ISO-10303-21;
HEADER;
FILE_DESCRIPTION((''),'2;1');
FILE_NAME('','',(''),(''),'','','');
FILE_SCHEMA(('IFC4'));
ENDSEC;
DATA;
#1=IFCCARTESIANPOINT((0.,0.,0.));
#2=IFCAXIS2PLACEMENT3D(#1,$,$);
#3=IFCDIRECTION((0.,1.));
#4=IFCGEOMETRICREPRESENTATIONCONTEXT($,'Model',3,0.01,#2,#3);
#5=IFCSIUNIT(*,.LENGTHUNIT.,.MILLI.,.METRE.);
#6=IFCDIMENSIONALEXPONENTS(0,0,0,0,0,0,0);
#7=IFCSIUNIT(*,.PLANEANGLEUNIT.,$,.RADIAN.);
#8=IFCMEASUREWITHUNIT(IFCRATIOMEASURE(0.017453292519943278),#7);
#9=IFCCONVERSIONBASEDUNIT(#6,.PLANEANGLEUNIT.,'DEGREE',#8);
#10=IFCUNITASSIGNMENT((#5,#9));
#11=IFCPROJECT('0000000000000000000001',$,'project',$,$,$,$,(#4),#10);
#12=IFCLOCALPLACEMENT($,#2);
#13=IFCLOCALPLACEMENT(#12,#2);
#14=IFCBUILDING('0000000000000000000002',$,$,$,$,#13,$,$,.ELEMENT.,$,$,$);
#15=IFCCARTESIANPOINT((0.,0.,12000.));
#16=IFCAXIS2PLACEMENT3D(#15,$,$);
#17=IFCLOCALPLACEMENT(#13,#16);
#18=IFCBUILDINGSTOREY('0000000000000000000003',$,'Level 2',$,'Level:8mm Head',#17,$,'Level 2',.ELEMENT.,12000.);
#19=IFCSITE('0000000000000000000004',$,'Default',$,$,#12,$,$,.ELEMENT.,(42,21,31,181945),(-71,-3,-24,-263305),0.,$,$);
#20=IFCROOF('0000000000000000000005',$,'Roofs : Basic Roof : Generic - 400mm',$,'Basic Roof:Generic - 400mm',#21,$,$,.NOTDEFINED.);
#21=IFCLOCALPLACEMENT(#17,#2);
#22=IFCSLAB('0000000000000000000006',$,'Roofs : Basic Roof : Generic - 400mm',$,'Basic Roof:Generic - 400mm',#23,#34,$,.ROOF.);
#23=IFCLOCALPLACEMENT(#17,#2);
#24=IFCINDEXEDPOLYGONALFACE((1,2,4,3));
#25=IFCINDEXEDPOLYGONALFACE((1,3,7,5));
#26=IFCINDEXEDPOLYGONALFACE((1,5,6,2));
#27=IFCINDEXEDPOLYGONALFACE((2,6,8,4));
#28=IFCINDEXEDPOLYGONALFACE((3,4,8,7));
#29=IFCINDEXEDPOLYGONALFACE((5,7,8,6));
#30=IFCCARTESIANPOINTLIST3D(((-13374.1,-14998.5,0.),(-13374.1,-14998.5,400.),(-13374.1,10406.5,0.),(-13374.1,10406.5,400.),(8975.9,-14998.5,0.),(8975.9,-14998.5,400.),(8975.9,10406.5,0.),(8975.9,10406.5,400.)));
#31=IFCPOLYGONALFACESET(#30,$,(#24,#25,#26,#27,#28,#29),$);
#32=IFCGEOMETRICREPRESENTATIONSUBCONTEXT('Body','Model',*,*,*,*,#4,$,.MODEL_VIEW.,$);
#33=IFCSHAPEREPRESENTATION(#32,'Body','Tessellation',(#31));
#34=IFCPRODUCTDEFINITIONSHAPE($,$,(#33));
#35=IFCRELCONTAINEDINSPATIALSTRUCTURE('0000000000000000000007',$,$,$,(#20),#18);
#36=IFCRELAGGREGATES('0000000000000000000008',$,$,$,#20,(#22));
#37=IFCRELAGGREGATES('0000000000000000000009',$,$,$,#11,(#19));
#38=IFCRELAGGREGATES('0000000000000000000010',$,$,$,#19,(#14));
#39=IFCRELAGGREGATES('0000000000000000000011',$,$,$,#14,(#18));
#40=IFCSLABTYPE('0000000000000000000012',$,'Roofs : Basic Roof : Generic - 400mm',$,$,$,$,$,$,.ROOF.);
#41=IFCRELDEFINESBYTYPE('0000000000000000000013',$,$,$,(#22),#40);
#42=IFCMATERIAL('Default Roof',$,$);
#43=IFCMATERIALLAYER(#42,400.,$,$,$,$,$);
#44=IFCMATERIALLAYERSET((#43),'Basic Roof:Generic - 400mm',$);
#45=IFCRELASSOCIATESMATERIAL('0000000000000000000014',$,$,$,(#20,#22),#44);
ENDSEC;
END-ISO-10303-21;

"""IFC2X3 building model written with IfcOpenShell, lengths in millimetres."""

from ifc_helpers import new_model, entity, si_unit, converted_unit, direction, frame, frame_2d, origin, place, context, subcontext, project, spatial, rectangle, extrude, material, layer, layer_set, type_object, element, aggregate, save


model = new_model("IFC2X3")

# Units and contexts
model_context = context("Model", 3, precision=0.01, world=origin(), true_north=direction((0.0, 1.0)))
body_context = subcontext(model_context, "Body", "Model", "MODEL_VIEW")
ifc_project = project(units=[si_unit("LENGTHUNIT", "METRE", prefix="MILLI"), converted_unit("PLANEANGLEUNIT", "DEGREE", entity("IfcRatioMeasure", 0.017453292519943278), si_unit("PLANEANGLEUNIT", "RADIAN"), dimensions=[0, 0, 0, 0, 0, 0, 0])], contexts=[model_context])

# Site, building, storey
site_placement = place(None, origin())
site = spatial("IfcSite", under=ifc_project, at=site_placement, Name="Default", CompositionType="ELEMENT", RefLatitude=(42, 21, 31, 181945), RefLongitude=(-71, -3, -24, -263305), RefElevation=0.0)
building_placement = place(site_placement, origin())
building = spatial("IfcBuilding", under=site, at=building_placement, CompositionType="ELEMENT")
storey_placement = place(building_placement, frame((0.0, 0.0, 12000.0)))
storey = spatial("IfcBuildingStorey", under=building, at=storey_placement, Name="Level 2", ObjectType="Level:8mm Head", LongName="Level 2", CompositionType="ELEMENT", Elevation=12000.0)

# Roof, slab
ifc_material = material(Name="Default Roof")
ifc_layer = layer(ifc_material, 400.0)
ifc_layer_set = layer_set([ifc_layer], Name="Basic Roof:Generic - 400mm")
roof_placement = place(storey_placement, frame((-13374.1, -14998.5, 0.0)))
roof = element("IfcRoof", 1, at=roof_placement, inside=storey, material=ifc_layer_set, Name="Roofs : Basic Roof : Generic - 400mm", ObjectType="Basic Roof:Generic - 400mm", ShapeType="NOTDEFINED")
slab_type = type_object("IfcSlabType", Name="Roofs : Basic Roof : Generic - 400mm", PredefinedType="ROOF")
slab_placement = place(roof_placement, origin())
slab = element("IfcSlab", 2, at=slab_placement, type_object=slab_type, material=ifc_layer_set, Name="Roofs : Basic Roof : Generic - 400mm", ObjectType="Basic Roof:Generic - 400mm", PredefinedType="ROOF", context=body_context, shape_type="SweptSolid", body=[
    extrude(rectangle(XDim=22350.0, YDim=25405.0, at=frame_2d((0.0, 0.0), x_axis=(1.0, 0.0))), frame((11175.0, 12702.5, 0.0)), (0.0, 0.0, 1.0), 400.0),
])
aggregate(roof, [slab])

save(model, "model.ifc")
